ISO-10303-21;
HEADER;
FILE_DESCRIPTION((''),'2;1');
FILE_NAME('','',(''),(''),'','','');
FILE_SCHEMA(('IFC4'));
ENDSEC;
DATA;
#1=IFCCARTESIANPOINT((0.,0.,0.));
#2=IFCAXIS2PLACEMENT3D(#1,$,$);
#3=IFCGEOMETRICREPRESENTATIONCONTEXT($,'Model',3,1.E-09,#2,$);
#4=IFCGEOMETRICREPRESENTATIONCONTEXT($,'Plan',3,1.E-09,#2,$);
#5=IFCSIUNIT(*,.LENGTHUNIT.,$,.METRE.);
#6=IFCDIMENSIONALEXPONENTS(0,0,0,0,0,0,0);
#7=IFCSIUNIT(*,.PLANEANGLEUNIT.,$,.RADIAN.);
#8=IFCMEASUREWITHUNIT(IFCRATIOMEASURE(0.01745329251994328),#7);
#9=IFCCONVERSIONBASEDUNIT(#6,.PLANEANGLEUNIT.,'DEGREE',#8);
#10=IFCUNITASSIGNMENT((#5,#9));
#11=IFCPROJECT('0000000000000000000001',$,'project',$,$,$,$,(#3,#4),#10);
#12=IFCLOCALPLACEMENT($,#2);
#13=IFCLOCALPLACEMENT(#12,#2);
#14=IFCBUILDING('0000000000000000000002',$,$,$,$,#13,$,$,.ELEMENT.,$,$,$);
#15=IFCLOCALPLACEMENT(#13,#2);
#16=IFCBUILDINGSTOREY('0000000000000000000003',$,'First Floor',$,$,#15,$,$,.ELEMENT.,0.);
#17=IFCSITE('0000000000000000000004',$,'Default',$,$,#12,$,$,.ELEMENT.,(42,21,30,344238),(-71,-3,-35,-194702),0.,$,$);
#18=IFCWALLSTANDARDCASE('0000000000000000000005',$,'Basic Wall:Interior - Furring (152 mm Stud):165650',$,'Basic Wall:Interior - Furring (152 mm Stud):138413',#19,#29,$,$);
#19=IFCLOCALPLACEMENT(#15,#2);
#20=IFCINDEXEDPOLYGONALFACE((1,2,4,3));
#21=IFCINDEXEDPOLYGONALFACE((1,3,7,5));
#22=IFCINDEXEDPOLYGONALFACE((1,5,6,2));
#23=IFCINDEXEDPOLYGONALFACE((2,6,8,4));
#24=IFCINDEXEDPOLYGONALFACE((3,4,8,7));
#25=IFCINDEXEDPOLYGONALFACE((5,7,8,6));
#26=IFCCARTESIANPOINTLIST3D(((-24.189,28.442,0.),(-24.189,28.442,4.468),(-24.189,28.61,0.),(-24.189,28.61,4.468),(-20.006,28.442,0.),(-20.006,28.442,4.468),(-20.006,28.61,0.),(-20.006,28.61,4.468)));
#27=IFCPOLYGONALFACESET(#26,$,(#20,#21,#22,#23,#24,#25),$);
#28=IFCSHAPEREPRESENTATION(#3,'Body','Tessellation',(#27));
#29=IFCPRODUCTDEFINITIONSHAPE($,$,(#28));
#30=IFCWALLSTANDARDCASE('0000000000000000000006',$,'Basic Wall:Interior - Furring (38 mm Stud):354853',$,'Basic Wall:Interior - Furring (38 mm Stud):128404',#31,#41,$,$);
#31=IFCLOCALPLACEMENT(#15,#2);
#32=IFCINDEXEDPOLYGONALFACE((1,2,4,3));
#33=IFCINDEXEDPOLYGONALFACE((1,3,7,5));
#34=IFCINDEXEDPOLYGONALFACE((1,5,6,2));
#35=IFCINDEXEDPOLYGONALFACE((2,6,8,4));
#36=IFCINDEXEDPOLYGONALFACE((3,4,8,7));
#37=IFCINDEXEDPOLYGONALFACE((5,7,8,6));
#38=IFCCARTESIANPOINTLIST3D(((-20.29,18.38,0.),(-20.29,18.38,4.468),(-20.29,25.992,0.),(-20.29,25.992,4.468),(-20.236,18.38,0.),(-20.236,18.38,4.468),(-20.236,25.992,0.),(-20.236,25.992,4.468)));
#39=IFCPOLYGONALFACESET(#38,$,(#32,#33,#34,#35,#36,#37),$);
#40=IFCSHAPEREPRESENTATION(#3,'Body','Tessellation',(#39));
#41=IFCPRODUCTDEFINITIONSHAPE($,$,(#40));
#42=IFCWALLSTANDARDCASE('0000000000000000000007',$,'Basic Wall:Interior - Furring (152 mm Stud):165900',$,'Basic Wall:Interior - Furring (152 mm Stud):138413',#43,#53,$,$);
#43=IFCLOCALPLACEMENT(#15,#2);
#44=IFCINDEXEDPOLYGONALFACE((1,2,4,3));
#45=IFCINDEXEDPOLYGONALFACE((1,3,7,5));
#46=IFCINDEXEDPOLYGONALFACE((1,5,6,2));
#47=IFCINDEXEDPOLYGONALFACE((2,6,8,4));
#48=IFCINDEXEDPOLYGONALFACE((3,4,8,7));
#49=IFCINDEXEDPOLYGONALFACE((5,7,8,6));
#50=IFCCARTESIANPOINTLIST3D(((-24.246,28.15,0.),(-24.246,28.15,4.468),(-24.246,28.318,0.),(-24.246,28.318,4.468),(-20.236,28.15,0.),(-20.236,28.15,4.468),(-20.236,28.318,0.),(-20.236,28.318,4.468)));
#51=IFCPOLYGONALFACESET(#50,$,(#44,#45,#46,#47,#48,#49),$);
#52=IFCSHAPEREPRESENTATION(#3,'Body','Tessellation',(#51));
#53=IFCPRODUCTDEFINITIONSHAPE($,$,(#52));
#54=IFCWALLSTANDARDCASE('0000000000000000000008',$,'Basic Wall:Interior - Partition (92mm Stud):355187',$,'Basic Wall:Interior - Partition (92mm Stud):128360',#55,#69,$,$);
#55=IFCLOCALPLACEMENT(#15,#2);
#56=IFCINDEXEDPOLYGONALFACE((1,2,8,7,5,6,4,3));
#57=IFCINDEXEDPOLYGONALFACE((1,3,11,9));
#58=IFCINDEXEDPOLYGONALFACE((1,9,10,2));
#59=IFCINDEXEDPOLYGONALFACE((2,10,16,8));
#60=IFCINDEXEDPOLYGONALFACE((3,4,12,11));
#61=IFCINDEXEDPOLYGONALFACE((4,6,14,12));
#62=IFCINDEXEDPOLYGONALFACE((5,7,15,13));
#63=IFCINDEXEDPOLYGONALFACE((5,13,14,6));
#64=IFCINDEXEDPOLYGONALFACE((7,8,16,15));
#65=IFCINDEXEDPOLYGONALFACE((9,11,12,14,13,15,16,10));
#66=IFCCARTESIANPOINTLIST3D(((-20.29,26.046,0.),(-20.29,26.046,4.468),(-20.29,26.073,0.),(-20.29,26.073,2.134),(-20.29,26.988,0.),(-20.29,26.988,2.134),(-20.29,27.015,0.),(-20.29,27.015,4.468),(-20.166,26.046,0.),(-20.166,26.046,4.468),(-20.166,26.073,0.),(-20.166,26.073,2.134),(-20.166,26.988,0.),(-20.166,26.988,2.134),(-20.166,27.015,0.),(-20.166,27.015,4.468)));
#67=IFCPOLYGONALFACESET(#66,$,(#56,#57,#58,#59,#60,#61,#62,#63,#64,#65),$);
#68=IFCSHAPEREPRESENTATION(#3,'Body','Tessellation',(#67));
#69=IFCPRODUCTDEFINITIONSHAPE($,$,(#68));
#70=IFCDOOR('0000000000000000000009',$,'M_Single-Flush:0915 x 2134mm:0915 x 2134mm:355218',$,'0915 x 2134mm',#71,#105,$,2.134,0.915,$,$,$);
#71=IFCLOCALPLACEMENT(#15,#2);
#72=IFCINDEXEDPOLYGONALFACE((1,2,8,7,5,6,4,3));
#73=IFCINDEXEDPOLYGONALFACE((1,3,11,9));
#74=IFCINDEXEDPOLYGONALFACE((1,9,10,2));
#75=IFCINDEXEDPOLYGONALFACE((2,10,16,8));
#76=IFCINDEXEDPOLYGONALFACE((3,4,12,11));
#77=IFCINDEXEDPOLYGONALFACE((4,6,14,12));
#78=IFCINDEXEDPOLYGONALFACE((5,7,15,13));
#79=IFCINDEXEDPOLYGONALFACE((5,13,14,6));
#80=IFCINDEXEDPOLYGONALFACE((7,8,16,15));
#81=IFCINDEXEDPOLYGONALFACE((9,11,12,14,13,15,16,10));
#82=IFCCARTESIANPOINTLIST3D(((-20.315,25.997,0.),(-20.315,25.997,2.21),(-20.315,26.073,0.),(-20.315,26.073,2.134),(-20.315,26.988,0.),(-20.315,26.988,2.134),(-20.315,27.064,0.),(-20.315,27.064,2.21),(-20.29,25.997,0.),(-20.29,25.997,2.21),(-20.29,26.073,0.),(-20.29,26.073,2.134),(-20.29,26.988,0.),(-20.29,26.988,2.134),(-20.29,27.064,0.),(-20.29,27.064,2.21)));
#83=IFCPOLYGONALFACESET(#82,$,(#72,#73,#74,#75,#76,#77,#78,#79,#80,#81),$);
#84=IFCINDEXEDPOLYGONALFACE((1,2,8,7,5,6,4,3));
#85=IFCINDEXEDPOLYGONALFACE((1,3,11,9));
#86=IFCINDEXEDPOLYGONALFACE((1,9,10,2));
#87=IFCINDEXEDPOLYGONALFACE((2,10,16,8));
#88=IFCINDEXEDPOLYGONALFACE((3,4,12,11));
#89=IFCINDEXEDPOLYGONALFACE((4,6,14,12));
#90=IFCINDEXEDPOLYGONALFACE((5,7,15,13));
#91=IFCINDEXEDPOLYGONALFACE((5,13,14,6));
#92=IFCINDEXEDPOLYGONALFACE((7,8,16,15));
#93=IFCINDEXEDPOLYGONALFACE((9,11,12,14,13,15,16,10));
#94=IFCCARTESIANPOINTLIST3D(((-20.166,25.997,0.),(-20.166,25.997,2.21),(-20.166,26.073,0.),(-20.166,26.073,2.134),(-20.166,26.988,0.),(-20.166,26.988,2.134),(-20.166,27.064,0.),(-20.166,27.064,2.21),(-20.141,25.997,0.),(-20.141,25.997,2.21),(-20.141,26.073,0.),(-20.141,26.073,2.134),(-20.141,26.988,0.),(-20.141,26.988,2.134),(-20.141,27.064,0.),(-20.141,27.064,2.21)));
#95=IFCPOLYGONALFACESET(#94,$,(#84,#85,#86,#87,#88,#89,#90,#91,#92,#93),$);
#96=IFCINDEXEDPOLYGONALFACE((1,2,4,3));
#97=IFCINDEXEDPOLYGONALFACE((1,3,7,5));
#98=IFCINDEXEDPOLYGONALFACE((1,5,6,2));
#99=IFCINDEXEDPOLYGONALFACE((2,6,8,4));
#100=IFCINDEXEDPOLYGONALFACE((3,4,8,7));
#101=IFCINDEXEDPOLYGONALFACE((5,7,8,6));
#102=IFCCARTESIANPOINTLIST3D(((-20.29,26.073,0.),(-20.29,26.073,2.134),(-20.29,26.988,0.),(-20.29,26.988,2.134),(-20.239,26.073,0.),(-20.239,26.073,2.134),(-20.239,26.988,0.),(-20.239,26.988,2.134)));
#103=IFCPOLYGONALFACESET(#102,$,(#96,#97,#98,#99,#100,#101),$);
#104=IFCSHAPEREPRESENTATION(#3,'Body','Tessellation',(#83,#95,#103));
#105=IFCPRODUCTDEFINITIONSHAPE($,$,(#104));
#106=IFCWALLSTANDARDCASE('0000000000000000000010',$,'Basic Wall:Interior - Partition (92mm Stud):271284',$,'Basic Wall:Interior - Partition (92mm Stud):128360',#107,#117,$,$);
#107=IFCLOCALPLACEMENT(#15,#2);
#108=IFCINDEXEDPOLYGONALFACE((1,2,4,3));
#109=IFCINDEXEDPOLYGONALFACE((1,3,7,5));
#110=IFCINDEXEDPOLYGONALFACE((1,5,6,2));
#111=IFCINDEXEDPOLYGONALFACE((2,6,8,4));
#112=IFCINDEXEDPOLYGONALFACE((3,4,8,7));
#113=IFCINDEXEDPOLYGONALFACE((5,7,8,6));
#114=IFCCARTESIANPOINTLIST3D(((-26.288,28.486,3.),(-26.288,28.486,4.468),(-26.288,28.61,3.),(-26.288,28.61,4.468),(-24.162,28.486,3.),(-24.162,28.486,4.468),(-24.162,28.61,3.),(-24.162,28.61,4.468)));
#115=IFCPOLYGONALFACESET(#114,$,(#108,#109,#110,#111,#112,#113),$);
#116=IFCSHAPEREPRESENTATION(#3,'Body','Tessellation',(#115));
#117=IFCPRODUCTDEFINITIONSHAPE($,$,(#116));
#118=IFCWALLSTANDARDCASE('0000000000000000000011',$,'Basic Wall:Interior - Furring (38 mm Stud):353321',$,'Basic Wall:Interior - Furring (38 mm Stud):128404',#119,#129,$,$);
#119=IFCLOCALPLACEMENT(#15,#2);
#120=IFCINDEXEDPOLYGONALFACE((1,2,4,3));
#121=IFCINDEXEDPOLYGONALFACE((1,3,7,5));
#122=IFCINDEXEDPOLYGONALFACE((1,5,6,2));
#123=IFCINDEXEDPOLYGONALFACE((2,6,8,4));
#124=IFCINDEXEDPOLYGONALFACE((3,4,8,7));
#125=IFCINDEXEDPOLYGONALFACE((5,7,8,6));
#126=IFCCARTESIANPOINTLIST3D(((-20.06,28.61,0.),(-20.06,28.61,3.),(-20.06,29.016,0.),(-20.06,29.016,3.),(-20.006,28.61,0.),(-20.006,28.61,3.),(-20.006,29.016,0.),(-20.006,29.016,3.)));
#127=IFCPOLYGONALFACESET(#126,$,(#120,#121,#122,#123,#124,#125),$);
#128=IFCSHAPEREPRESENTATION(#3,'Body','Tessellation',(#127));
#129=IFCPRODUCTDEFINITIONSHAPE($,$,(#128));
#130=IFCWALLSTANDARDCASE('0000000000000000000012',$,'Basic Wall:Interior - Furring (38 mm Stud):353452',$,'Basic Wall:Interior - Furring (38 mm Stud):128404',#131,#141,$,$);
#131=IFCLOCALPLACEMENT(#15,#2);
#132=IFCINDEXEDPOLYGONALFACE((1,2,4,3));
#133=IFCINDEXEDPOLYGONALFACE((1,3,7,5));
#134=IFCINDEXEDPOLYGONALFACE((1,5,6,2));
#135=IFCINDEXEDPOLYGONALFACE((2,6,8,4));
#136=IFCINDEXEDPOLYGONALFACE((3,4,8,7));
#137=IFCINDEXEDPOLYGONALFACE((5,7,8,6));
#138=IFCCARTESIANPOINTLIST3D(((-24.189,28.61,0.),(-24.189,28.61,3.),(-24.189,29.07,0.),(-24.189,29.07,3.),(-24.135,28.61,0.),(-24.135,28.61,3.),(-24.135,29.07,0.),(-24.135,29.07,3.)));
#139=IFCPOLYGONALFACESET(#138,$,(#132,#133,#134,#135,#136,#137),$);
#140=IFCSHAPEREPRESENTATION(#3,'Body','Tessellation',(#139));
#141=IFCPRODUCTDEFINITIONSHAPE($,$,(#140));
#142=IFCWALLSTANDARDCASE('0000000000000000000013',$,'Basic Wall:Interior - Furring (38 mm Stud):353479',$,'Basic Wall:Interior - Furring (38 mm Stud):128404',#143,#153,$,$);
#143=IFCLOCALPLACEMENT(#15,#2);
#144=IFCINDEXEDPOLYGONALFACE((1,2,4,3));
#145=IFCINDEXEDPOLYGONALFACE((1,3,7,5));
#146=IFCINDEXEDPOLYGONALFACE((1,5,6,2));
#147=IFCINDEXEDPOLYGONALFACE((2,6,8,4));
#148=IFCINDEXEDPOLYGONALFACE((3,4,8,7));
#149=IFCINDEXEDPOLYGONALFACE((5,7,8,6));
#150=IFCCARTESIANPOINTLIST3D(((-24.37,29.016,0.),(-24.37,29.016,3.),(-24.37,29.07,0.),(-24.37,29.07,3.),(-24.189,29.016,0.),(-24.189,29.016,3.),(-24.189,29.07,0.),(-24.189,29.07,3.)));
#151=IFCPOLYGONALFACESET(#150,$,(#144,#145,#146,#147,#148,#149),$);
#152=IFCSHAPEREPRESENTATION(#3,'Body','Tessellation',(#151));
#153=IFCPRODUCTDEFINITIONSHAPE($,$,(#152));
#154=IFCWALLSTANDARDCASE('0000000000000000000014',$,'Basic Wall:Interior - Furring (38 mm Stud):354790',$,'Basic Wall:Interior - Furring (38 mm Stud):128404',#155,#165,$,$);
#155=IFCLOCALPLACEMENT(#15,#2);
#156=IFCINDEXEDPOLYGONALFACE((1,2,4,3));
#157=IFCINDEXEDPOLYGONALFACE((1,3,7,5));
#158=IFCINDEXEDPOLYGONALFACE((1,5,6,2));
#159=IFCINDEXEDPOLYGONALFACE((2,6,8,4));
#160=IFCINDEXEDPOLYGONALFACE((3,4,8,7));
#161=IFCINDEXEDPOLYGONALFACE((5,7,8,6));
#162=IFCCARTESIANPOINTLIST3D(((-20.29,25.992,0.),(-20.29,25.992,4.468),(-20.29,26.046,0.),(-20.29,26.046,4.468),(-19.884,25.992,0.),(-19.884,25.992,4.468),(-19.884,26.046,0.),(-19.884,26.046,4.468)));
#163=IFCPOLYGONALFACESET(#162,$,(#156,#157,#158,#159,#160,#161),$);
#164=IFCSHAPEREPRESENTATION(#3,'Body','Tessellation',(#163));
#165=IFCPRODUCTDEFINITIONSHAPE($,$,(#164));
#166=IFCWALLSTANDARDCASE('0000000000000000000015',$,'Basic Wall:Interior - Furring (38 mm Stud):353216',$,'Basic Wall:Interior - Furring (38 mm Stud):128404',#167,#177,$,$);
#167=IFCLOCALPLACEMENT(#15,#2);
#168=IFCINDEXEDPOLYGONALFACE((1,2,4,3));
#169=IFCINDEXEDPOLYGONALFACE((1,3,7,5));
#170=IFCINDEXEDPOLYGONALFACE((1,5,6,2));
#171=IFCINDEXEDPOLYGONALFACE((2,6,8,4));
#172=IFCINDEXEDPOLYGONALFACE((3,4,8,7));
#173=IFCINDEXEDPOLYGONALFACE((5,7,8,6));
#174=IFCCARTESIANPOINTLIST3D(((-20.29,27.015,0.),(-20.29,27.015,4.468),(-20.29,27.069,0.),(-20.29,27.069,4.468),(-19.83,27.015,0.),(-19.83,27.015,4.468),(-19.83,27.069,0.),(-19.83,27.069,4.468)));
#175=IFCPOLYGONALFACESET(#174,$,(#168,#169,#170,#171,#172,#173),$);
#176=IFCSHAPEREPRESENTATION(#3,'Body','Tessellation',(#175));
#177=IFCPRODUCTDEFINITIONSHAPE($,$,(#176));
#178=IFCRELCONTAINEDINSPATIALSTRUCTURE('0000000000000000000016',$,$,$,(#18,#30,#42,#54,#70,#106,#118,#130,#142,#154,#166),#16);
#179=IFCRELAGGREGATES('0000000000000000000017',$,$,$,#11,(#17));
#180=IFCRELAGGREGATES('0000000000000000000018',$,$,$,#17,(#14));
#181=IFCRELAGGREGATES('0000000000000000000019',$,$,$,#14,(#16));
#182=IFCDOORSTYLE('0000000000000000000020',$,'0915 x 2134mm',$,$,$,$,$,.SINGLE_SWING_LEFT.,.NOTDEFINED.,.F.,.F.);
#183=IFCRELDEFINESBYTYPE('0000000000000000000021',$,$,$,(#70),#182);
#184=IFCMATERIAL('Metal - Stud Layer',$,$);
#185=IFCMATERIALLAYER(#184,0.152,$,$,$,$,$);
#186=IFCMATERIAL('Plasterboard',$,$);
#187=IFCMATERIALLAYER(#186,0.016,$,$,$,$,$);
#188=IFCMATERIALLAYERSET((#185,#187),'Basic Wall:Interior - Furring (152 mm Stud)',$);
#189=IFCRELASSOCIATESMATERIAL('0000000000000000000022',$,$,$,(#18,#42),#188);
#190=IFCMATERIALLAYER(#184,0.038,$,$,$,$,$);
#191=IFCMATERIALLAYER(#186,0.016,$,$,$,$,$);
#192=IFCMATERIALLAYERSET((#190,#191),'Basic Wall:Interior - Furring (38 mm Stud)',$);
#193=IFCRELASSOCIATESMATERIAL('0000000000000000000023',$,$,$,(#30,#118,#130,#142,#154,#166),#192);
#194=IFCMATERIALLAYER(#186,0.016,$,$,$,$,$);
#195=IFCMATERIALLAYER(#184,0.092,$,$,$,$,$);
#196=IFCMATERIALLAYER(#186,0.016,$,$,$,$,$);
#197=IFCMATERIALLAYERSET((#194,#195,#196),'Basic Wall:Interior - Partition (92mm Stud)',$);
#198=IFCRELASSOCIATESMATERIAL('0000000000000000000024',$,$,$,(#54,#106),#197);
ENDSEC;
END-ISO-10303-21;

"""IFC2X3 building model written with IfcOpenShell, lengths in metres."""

from ifc_helpers import new_model, entity, si_unit, converted_unit, frame, frame_2d, origin, origin_2d_with_axis, place, context, project, spatial, polyline, rectangle, outline, extrude, source, transform, mapped, material, layer, layer_set, layer_usage, type_object, type_shapes, element, fill, save


model = new_model("IFC2X3")

# Units and contexts
model_context = context("Model", 3, precision=1e-09, world=origin())
plan_context = context("Plan", 3, precision=1e-09, world=origin())
ifc_project = project(units=[si_unit("LENGTHUNIT", "METRE"), converted_unit("PLANEANGLEUNIT", "DEGREE", entity("IfcRatioMeasure", 0.01745329251994328), si_unit("PLANEANGLEUNIT", "RADIAN"), dimensions=[0, 0, 0, 0, 0, 0, 0])], contexts=[model_context, plan_context])

# Site, building, storey
site_placement = place(None, origin())
site = spatial("IfcSite", under=ifc_project, at=site_placement, Name="Default", CompositionType="ELEMENT", RefLatitude=(42, 21, 30, 344238), RefLongitude=(-71, -3, -35, -194702), RefElevation=0.0)
building_placement = place(site_placement, origin())
building = spatial("IfcBuilding", under=site, at=building_placement, CompositionType="ELEMENT")
storey_placement = place(building_placement, origin())
storey = spatial("IfcBuildingStorey", under=building, at=storey_placement, Name="First Floor", CompositionType="ELEMENT", Elevation=0.0)

# Shared definitions
ifc_material_1 = material(Name="Metal - Stud Layer")
ifc_layer_1 = layer(ifc_material_1, 0.152)
ifc_material_2 = material(Name="Plasterboard")
ifc_layer_2 = layer(ifc_material_2, 0.016)
ifc_layer_set_1 = layer_set([ifc_layer_1, ifc_layer_2], Name="Basic Wall:Interior - Furring (152 mm Stud)")
ifc_layer_usage_1 = layer_usage(ifc_layer_set_1, "AXIS2", "POSITIVE", -0.084)

# Walls
wall_1_placement = place(storey_placement, frame((-24.189, 28.526, 0.0)))
element("IfcWallStandardCase", 1, at=wall_1_placement, inside=storey, material=ifc_layer_usage_1, Name="Basic Wall:Interior - Furring (152 mm Stud):165650", ObjectType="Basic Wall:Interior - Furring (152 mm Stud):138413", context=model_context, shape_type="SweptSolid", body=[
    extrude(rectangle(XDim=4.183, YDim=0.168, at=frame_2d((2.0915, 0.0), x_axis=(-1.0, 0.0))), origin(), (0.0, 0.0, 1.0), 4.468),
])
ifc_layer_3 = layer(ifc_material_1, 0.038)
ifc_layer_4 = layer(ifc_material_2, 0.016)
ifc_layer_set_2 = layer_set([ifc_layer_3, ifc_layer_4], Name="Basic Wall:Interior - Furring (38 mm Stud)")
ifc_layer_usage_2 = layer_usage(ifc_layer_set_2, "AXIS2", "NEGATIVE", 0.027)
wall_2_placement = place(storey_placement, frame((-20.263, 25.992, 0.0), z_axis=(0.0, 0.0, 1.0), x_axis=(0.0, -1.0, 0.0)))
element("IfcWallStandardCase", 2, at=wall_2_placement, inside=storey, material=ifc_layer_usage_2, Name="Basic Wall:Interior - Furring (38 mm Stud):354853", ObjectType="Basic Wall:Interior - Furring (38 mm Stud):128404", context=model_context, shape_type="SweptSolid", body=[
    extrude(rectangle(XDim=7.612, YDim=0.054, at=frame_2d((3.806, 0.0), x_axis=(-1.0, 0.0))), origin(), (0.0, 0.0, 1.0), 4.468),
])
wall_3_placement = place(storey_placement, frame((-20.236, 28.234, 0.0), z_axis=(0.0, 0.0, 1.0), x_axis=(-1.0, 0.0, 0.0)))
element("IfcWallStandardCase", 3, at=wall_3_placement, inside=storey, material=ifc_layer_usage_1, Name="Basic Wall:Interior - Furring (152 mm Stud):165900", ObjectType="Basic Wall:Interior - Furring (152 mm Stud):138413", context=model_context, shape_type="SweptSolid", body=[
    extrude(rectangle(XDim=4.01, YDim=0.168, at=frame_2d((2.005, 0.0), x_axis=(-1.0, 0.0))), origin(), (0.0, 0.0, 1.0), 4.468),
])

# Wall, opening, door
ifc_layer_5 = layer(ifc_material_2, 0.016)
ifc_layer_6 = layer(ifc_material_1, 0.092)
ifc_layer_7 = layer(ifc_material_2, 0.016)
ifc_layer_set_3 = layer_set([ifc_layer_5, ifc_layer_6, ifc_layer_7], Name="Basic Wall:Interior - Partition (92mm Stud)")
ifc_layer_usage_3 = layer_usage(ifc_layer_set_3, "AXIS2", "POSITIVE", -0.062)
wall_4_placement = place(storey_placement, frame((-20.228, 27.015, 0.0), z_axis=(0.0, 0.0, 1.0), x_axis=(0.0, -1.0, 0.0)))
wall_4 = element("IfcWallStandardCase", 4, at=wall_4_placement, inside=storey, material=ifc_layer_usage_3, Name="Basic Wall:Interior - Partition (92mm Stud):355187", ObjectType="Basic Wall:Interior - Partition (92mm Stud):128360", context=model_context, shape_type="SweptSolid", body=[
    extrude(rectangle(XDim=0.969, YDim=0.124, at=frame_2d((0.4845, 0.0), x_axis=(-1.0, 0.0))), origin(), (0.0, 0.0, 1.0), 4.468),
])
opening_1_placement = place(wall_4_placement, frame((0.942, 0.062, 0.0)))
opening_1 = element("IfcOpeningElement", 5, at=opening_1_placement, cuts=wall_4, ObjectType="Opening", context=model_context, shape_type="SweptSolid", body=[
    extrude(rectangle(XDim=0.915, YDim=2.134, at=frame_2d((1.067, 0.4575), x_axis=(0.0, -1.0))), frame((0.0, 0.0, 0.0), z_axis=(0.0, -1.0, 0.0), x_axis=(0.0, 0.0, 1.0)), (0.0, 0.0, 1.0), 0.124),
])
door_style = type_object("IfcDoorStyle", Name="0915 x 2134mm", ConstructionType="NOTDEFINED", OperationType="SINGLE_SWING_LEFT", ParameterTakesPrecedence=False, Sizeable=False)
shared_shape_1 = source(origin(), model_context, "Body", "SweptSolid", [
    extrude(outline(polyline([(-0.5335, -1.124), (0.5335, -1.124), (0.5335, 1.086), (0.4575, 1.086), (0.4575, -1.048), (-0.4575, -1.048), (-0.4575, 1.086), (-0.5335, 1.086), (-0.5335, -1.124)])), frame((0.4575, 0.149, 1.086), z_axis=(0.0, -1.0, 0.0), x_axis=(-1.0, 0.0, 0.0)), (0.0, 0.0, 1.0), 0.025),
    extrude(outline(polyline([(-1.124, -0.5335), (1.086, -0.5335), (1.086, -0.4575), (-1.048, -0.4575), (-1.048, 0.4575), (1.086, 0.4575), (1.086, 0.5335), (-1.124, 0.5335), (-1.124, -0.5335)])), frame((0.4575, 0.0, 1.086), z_axis=(0.0, -1.0, 0.0), x_axis=(0.0, 0.0, -1.0)), (0.0, 0.0, 1.0), 0.025),
    extrude(rectangle(XDim=0.915, YDim=0.051, at=origin_2d_with_axis()), frame((0.4575, 0.0985, 0.0)), (0.0, 0.0, 1.0), 2.134),
])
type_shapes(door_style, [shared_shape_1])
door_placement = place(opening_1_placement, frame((0.0, 0.0, 0.0), z_axis=(0.0, 0.0, 1.0), x_axis=(-1.0, 0.0, 0.0)))
door = element("IfcDoor", 6, at=door_placement, inside=storey, type_object=door_style, Name="M_Single-Flush:0915 x 2134mm:0915 x 2134mm:355218", ObjectType="0915 x 2134mm", OverallHeight=2.134, OverallWidth=0.915, context=model_context, shape_type="MappedRepresentation", body=[
    mapped(shared_shape_1, transform((0.0, 0.0, 0.0), scale=1.0)),
])
fill(opening_1, door)

# Walls
ifc_layer_usage_4 = layer_usage(ifc_layer_set_3, "AXIS2", "NEGATIVE", 0.062)
wall_5_placement = place(storey_placement, frame((-24.162, 28.548, 3.0), z_axis=(0.0, 0.0, 1.0), x_axis=(-1.0, 0.0, 0.0)))
element("IfcWallStandardCase", 7, at=wall_5_placement, inside=storey, material=ifc_layer_usage_4, Name="Basic Wall:Interior - Partition (92mm Stud):271284", ObjectType="Basic Wall:Interior - Partition (92mm Stud):128360", context=model_context, shape_type="SweptSolid", body=[
    extrude(rectangle(XDim=2.126, YDim=0.124, at=frame_2d((1.063, 0.0), x_axis=(-1.0, 0.0))), origin(), (0.0, 0.0, 1.0), 1.468),
])
wall_6_placement = place(storey_placement, frame((-20.033, 29.016, 0.0), z_axis=(0.0, 0.0, 1.0), x_axis=(0.0, -1.0, 0.0)))
element("IfcWallStandardCase", 8, at=wall_6_placement, inside=storey, material=ifc_layer_usage_2, Name="Basic Wall:Interior - Furring (38 mm Stud):353321", ObjectType="Basic Wall:Interior - Furring (38 mm Stud):128404", context=model_context, shape_type="SweptSolid", body=[
    extrude(rectangle(XDim=0.406, YDim=0.054, at=frame_2d((0.203, 0.0), x_axis=(-1.0, 0.0))), origin(), (0.0, 0.0, 1.0), 3.0),
])
wall_7_placement = place(storey_placement, frame((-24.162, 28.61, 0.0), z_axis=(0.0, 0.0, 1.0), x_axis=(0.0, 1.0, 0.0)))
element("IfcWallStandardCase", 9, at=wall_7_placement, inside=storey, material=ifc_layer_usage_2, Name="Basic Wall:Interior - Furring (38 mm Stud):353452", ObjectType="Basic Wall:Interior - Furring (38 mm Stud):128404", context=model_context, shape_type="SweptSolid", body=[
    extrude(rectangle(XDim=0.46, YDim=0.054, at=frame_2d((0.23, 0.0), x_axis=(-1.0, 0.0))), origin(), (0.0, 0.0, 1.0), 3.0),
])
wall_8_placement = place(storey_placement, frame((-24.189, 29.043, 0.0), z_axis=(0.0, 0.0, 1.0), x_axis=(-1.0, 0.0, 0.0)))
element("IfcWallStandardCase", 10, at=wall_8_placement, inside=storey, material=ifc_layer_usage_2, Name="Basic Wall:Interior - Furring (38 mm Stud):353479", ObjectType="Basic Wall:Interior - Furring (38 mm Stud):128404", context=model_context, shape_type="SweptSolid", body=[
    extrude(rectangle(XDim=0.181, YDim=0.054, at=frame_2d((0.0905, 0.0), x_axis=(-1.0, 0.0))), origin(), (0.0, 0.0, 1.0), 3.0),
])
wall_9_placement = place(storey_placement, frame((-19.884, 26.019, 0.0), z_axis=(0.0, 0.0, 1.0), x_axis=(-1.0, 0.0, 0.0)))
element("IfcWallStandardCase", 11, at=wall_9_placement, inside=storey, material=ifc_layer_usage_2, Name="Basic Wall:Interior - Furring (38 mm Stud):354790", ObjectType="Basic Wall:Interior - Furring (38 mm Stud):128404", context=model_context, shape_type="SweptSolid", body=[
    extrude(rectangle(XDim=0.406, YDim=0.054, at=frame_2d((0.203, 0.0), x_axis=(-1.0, 0.0))), origin(), (0.0, 0.0, 1.0), 4.468),
])
wall_10_placement = place(storey_placement, frame((-20.29, 27.042, 0.0)))
element("IfcWallStandardCase", 12, at=wall_10_placement, inside=storey, material=ifc_layer_usage_2, Name="Basic Wall:Interior - Furring (38 mm Stud):353216", ObjectType="Basic Wall:Interior - Furring (38 mm Stud):128404", context=model_context, shape_type="SweptSolid", body=[
    extrude(rectangle(XDim=0.46, YDim=0.054, at=frame_2d((0.23, 0.0), x_axis=(-1.0, 0.0))), origin(), (0.0, 0.0, 1.0), 4.468),
])

save(model, "model.ifc")
